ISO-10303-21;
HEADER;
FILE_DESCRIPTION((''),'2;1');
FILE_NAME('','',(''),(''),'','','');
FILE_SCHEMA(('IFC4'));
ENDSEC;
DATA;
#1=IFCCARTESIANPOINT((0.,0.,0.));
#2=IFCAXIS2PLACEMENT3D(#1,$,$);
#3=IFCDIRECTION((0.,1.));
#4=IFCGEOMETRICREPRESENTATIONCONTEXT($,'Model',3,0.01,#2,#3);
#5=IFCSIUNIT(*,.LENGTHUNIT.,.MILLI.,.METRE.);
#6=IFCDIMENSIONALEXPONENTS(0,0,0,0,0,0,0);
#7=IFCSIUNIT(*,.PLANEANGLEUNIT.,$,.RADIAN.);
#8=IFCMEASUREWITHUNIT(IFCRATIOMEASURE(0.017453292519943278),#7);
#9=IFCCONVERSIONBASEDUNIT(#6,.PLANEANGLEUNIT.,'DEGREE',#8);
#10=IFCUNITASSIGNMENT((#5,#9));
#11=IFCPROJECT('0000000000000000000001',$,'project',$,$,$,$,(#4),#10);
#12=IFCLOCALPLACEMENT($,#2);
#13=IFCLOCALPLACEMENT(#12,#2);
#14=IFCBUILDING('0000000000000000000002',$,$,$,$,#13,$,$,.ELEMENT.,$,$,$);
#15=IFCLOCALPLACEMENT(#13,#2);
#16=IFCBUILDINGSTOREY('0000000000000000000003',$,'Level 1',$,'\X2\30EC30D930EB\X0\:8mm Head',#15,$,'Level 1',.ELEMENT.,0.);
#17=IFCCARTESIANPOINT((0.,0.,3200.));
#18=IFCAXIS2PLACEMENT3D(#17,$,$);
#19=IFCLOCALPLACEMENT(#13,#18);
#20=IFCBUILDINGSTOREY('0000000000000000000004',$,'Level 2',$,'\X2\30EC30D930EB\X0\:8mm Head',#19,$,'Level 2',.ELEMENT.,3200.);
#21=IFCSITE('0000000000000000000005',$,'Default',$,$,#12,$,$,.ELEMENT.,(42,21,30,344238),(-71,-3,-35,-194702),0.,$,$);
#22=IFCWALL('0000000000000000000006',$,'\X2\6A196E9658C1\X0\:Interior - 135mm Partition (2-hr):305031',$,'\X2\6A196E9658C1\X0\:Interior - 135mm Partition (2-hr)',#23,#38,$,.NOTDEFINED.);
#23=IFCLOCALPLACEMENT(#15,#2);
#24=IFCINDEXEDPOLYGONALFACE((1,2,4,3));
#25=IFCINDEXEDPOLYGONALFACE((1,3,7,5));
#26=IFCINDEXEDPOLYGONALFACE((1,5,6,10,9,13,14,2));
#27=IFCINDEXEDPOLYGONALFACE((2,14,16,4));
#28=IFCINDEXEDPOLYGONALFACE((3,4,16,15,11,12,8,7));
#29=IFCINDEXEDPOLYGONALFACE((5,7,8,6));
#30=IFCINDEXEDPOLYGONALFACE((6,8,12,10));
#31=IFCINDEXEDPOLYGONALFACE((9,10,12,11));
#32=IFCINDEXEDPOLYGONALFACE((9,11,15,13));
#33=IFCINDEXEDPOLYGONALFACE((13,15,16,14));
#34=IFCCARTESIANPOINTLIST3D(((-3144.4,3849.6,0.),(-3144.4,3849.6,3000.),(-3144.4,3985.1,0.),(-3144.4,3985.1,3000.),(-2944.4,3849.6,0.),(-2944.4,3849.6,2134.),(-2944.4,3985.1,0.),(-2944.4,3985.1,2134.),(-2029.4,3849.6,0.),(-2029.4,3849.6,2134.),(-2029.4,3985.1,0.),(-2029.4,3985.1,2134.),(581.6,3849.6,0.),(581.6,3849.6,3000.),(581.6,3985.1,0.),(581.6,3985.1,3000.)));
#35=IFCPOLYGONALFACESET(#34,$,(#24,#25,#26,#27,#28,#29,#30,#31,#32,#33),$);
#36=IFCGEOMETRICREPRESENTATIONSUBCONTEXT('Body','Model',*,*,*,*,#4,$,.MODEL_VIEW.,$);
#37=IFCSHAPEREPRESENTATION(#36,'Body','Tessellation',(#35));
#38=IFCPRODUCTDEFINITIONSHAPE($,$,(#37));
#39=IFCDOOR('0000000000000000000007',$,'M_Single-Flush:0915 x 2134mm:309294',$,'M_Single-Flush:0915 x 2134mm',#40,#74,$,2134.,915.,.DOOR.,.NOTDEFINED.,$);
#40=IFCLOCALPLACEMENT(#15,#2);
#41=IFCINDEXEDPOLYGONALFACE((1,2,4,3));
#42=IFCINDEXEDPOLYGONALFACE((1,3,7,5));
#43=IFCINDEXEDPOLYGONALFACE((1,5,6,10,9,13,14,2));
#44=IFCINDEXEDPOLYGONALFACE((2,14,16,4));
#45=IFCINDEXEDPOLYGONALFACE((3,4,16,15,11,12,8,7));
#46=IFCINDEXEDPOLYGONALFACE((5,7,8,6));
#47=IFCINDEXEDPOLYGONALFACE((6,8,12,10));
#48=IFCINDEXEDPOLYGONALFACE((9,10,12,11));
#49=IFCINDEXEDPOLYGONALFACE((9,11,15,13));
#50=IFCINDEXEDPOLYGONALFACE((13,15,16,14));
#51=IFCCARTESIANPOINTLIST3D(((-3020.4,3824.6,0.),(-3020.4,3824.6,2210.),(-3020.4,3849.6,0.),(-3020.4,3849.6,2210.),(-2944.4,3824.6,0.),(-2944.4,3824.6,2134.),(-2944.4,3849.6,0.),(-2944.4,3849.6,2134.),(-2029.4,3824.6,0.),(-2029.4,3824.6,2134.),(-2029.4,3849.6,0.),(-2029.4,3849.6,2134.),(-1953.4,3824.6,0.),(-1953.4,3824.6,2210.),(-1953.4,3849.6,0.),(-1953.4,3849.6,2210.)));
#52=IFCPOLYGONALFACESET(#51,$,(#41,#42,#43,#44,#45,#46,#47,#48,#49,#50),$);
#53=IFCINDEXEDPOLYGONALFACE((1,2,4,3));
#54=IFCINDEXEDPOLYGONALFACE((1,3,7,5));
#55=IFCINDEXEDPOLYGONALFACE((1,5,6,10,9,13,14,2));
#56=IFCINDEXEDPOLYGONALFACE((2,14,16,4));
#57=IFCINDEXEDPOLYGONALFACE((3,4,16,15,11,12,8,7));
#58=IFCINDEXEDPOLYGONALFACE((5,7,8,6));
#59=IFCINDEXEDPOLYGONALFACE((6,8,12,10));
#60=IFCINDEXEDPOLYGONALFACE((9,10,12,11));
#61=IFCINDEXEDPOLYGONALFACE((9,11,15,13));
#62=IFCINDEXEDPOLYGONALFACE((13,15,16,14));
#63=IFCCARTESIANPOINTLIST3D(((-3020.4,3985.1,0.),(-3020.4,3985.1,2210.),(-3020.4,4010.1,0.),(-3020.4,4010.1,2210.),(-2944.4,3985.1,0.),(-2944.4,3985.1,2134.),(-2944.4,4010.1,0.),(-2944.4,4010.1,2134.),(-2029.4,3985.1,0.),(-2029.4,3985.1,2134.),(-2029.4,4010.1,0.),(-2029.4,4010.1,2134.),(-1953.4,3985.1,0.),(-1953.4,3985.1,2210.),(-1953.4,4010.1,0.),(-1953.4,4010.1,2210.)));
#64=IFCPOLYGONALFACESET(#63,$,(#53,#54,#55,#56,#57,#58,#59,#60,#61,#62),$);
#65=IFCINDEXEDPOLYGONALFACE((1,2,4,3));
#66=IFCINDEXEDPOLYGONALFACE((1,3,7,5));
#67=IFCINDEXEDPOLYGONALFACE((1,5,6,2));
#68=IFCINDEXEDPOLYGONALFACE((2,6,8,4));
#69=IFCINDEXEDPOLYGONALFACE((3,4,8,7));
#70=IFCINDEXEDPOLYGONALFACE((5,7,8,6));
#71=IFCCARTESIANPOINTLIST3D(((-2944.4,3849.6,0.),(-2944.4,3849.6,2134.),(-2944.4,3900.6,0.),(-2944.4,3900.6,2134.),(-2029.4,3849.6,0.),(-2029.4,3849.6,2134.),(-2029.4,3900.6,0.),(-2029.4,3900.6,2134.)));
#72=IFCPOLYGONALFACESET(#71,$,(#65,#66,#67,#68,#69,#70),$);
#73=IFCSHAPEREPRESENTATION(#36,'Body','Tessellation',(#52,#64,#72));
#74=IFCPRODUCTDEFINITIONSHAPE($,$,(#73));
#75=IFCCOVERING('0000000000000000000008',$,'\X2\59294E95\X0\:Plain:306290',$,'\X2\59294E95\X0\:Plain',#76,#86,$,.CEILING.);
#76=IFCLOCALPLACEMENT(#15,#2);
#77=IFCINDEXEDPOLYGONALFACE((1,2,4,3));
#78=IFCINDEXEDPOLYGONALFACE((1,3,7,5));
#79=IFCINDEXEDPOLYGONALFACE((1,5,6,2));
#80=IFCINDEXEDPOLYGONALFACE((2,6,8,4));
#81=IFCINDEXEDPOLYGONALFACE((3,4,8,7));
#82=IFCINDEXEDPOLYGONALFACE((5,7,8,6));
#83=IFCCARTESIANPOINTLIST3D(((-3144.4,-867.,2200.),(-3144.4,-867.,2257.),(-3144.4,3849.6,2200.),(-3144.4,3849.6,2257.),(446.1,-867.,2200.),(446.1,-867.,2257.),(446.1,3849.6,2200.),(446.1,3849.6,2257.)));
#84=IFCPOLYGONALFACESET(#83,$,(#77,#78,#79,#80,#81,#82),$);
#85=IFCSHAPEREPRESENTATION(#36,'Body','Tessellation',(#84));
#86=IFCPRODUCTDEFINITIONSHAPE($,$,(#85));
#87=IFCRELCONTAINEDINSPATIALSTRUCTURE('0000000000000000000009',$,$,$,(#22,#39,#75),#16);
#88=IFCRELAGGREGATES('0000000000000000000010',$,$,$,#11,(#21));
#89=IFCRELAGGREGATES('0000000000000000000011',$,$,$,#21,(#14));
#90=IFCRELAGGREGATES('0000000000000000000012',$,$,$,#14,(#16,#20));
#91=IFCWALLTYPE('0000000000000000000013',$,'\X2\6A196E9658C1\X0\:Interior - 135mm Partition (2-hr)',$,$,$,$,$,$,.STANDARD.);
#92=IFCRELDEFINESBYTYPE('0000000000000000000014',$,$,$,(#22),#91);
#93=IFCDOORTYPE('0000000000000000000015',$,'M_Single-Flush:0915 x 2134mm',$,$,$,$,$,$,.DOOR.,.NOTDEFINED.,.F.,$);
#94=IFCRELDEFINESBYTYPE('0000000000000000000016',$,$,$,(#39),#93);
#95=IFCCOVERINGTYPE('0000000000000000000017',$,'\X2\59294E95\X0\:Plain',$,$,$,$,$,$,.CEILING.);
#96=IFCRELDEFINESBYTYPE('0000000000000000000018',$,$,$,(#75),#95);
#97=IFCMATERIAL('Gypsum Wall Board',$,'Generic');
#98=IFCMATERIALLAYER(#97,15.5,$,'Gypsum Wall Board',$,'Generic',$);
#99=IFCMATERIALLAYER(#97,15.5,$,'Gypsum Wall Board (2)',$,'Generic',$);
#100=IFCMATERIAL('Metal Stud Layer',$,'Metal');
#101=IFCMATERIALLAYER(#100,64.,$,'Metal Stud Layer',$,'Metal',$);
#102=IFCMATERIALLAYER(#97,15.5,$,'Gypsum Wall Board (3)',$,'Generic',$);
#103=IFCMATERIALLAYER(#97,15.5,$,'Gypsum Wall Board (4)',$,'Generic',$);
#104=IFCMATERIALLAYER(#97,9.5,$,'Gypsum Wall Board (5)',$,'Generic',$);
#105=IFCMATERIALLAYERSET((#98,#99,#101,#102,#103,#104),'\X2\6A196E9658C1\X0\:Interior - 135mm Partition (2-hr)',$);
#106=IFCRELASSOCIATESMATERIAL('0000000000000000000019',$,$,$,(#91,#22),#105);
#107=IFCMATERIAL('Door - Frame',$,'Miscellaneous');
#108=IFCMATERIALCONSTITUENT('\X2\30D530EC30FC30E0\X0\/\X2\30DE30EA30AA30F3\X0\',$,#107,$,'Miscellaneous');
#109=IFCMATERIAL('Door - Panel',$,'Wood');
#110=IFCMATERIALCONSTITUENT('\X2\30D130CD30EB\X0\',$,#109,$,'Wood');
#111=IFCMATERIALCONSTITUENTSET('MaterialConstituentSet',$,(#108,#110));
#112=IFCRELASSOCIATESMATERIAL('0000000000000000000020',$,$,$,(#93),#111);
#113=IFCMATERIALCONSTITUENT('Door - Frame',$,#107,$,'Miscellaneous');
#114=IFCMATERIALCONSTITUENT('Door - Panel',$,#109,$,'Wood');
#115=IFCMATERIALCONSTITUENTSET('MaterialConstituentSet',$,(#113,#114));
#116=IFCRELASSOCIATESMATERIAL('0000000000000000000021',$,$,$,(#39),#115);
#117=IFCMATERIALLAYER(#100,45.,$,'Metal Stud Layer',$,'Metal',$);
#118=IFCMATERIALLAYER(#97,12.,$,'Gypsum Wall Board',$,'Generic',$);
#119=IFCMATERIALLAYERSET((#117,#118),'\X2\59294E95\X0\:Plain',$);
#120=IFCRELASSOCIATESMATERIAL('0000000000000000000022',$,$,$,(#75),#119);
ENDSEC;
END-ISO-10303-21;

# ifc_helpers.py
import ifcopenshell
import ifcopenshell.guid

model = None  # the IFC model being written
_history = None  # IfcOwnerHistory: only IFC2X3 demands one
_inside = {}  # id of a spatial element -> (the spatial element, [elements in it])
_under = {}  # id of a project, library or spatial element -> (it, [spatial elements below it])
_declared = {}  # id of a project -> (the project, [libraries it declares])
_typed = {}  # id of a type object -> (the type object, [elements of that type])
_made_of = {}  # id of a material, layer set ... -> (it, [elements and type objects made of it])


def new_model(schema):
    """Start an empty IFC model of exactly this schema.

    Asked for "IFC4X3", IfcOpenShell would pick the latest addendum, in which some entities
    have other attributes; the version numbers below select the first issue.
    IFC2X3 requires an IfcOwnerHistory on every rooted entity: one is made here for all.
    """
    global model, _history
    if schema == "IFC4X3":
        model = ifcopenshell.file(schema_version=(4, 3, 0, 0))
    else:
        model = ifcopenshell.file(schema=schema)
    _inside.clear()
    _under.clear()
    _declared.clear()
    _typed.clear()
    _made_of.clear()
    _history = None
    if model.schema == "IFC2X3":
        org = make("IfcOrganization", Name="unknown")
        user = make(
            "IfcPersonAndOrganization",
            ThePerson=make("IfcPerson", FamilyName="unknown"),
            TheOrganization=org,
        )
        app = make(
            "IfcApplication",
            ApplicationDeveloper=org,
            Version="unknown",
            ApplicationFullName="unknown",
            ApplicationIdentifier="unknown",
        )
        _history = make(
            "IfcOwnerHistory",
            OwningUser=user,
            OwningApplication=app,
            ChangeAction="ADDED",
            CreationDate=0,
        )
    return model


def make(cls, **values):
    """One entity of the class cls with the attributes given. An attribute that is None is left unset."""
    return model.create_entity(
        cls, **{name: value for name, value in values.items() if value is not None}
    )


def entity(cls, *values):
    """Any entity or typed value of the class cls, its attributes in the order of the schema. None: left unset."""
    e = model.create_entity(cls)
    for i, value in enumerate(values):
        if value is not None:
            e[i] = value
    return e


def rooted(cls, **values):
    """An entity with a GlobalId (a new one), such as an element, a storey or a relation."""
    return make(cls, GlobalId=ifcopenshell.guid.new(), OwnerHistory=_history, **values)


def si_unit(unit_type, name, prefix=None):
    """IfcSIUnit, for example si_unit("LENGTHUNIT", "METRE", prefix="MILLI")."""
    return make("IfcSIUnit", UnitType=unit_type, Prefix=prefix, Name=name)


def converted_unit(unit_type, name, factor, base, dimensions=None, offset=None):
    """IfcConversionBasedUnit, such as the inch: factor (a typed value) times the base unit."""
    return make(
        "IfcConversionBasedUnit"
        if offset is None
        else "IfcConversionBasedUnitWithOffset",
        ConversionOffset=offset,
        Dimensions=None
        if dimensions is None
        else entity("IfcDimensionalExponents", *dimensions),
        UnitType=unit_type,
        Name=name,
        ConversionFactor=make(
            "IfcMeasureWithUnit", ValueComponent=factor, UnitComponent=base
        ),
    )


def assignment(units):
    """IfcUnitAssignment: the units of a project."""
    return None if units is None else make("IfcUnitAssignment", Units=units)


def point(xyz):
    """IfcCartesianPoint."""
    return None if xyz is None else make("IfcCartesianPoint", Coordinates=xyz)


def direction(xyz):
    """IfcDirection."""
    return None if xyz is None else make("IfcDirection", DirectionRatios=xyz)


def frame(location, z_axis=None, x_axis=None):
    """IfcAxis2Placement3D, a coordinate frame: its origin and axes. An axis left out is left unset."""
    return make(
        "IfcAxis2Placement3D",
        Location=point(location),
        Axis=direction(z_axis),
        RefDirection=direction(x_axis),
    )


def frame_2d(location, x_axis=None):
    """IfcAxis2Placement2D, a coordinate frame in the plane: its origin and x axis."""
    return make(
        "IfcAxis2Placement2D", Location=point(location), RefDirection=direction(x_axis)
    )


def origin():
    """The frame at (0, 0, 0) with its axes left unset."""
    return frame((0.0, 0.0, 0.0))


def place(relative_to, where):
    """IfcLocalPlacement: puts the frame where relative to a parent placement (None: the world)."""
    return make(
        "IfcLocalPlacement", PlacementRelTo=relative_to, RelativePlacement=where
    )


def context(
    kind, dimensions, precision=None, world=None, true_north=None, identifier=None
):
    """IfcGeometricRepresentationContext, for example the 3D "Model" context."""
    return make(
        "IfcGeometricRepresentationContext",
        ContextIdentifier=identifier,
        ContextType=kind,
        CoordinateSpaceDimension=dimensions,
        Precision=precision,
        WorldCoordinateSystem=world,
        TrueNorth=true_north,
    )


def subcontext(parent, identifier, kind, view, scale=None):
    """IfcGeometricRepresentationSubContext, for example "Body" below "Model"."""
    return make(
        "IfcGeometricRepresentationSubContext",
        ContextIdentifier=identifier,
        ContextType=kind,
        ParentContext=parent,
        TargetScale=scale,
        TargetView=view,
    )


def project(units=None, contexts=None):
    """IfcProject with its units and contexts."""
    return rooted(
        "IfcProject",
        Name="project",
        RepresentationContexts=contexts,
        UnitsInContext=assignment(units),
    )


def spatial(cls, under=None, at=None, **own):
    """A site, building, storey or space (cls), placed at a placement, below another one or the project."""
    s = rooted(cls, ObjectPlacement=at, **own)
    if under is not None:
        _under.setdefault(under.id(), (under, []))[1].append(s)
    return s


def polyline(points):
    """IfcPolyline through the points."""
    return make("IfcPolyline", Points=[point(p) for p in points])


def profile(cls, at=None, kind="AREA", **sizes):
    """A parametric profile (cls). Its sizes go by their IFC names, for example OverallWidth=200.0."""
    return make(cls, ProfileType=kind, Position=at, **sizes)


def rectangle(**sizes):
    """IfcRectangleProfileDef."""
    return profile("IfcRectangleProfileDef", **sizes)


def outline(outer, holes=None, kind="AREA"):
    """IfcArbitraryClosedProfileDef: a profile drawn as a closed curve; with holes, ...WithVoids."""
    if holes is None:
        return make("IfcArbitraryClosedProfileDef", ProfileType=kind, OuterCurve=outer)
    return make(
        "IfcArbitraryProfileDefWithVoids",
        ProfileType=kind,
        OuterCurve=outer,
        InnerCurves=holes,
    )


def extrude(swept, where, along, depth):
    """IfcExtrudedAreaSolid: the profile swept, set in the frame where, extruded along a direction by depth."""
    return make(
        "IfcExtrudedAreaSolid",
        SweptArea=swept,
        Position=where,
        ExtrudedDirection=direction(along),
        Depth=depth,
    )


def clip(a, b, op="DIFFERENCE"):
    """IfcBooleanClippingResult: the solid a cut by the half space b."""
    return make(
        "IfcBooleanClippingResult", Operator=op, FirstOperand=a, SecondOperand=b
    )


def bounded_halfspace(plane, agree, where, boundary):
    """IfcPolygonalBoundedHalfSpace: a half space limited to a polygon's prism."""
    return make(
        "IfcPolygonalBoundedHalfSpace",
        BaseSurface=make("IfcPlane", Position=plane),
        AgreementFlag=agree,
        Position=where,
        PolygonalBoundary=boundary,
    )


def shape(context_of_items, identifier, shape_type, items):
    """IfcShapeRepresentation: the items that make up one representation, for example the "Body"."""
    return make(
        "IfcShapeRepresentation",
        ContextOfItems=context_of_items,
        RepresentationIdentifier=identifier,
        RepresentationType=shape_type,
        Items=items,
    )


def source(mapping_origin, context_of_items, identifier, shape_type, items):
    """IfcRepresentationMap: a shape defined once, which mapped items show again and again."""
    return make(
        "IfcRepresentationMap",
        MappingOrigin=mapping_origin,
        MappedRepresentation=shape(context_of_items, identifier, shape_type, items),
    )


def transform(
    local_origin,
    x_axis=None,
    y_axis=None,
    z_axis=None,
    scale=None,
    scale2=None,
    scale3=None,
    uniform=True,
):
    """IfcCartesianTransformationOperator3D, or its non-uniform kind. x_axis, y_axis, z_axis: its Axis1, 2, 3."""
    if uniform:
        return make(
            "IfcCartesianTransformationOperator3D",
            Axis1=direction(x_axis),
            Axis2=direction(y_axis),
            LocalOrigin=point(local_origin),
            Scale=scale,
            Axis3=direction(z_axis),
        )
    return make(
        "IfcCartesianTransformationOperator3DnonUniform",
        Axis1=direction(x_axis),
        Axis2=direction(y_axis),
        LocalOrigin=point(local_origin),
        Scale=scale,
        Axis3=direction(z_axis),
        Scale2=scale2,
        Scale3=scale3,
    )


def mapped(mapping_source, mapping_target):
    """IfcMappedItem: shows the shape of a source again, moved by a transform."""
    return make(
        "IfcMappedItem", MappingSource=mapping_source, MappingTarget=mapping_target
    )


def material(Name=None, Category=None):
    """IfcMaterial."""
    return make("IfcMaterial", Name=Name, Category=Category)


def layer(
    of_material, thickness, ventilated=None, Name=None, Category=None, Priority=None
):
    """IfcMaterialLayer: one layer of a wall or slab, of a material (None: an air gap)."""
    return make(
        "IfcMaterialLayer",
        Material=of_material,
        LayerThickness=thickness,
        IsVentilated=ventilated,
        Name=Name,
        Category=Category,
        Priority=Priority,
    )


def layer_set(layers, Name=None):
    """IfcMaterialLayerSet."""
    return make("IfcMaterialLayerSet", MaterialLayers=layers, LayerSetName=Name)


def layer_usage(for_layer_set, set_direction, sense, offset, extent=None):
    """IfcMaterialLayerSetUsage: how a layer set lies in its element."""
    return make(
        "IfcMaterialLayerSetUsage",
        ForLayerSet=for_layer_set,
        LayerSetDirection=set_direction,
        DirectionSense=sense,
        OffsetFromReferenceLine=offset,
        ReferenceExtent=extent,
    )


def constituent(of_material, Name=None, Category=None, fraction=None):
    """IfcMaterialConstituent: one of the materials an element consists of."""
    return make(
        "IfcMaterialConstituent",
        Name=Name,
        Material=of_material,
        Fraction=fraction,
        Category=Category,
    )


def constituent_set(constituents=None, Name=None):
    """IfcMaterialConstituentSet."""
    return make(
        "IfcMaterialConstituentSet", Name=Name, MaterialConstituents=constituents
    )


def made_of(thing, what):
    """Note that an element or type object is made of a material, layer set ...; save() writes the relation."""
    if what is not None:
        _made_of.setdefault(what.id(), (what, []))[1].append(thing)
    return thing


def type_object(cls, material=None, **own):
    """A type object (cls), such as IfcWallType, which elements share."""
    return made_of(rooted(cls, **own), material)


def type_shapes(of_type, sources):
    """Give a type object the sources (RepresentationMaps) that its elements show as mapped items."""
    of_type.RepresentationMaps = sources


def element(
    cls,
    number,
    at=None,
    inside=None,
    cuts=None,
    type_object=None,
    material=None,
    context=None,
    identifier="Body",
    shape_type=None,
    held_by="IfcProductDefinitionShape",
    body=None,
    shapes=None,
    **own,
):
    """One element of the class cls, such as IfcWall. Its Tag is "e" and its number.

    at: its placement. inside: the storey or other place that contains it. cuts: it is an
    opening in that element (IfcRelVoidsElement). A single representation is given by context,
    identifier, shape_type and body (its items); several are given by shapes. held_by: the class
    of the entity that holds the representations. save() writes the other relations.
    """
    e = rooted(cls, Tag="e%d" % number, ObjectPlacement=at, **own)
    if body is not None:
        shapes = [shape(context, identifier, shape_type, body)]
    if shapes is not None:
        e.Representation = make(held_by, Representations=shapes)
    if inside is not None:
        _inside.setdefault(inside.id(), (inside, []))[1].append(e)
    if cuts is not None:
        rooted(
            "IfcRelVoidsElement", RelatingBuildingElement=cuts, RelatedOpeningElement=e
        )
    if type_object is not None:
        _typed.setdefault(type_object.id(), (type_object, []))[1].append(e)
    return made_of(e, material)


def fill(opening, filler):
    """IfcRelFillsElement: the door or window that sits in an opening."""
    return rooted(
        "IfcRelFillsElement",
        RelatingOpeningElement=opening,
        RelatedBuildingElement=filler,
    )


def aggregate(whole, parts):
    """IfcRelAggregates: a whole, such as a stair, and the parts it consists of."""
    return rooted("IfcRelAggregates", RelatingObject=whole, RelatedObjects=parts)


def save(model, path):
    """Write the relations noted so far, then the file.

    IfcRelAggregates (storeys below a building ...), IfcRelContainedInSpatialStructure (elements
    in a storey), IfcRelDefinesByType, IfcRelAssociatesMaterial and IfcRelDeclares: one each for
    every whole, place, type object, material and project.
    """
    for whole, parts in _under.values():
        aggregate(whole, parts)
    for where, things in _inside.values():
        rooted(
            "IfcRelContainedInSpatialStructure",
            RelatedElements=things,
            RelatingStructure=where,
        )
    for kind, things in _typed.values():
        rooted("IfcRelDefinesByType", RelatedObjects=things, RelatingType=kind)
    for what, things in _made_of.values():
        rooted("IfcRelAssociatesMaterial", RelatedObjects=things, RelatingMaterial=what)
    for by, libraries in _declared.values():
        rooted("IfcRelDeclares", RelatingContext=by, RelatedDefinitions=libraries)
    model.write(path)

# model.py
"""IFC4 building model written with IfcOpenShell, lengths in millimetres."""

from ifc_helpers import new_model, entity, si_unit, converted_unit, direction, frame, frame_2d, origin, place, context, subcontext, project, spatial, polyline, rectangle, outline, extrude, clip, bounded_halfspace, source, transform, mapped, material, layer, layer_set, layer_usage, constituent, constituent_set, type_object, type_shapes, element, fill, save


model = new_model("IFC4")

# Units and contexts
model_context = context("Model", 3, precision=0.01, world=origin(), true_north=direction((0.0, 1.0)))
body_context = subcontext(model_context, "Body", "Model", "MODEL_VIEW")
ifc_project = project(units=[si_unit("LENGTHUNIT", "METRE", prefix="MILLI"), converted_unit("PLANEANGLEUNIT", "DEGREE", entity("IfcRatioMeasure", 0.017453292519943278), si_unit("PLANEANGLEUNIT", "RADIAN"), dimensions=[0, 0, 0, 0, 0, 0, 0])], contexts=[model_context])

# Site, building, storey
site_placement = place(None, origin())
site = spatial("IfcSite", under=ifc_project, at=site_placement, Name="Default", CompositionType="ELEMENT", RefLatitude=(42, 21, 30, 344238), RefLongitude=(-71, -3, -35, -194702), RefElevation=0.0)
building_placement = place(site_placement, origin())
building = spatial("IfcBuilding", under=site, at=building_placement, CompositionType="ELEMENT")
storey_1_placement = place(building_placement, origin())
storey_1 = spatial("IfcBuildingStorey", under=building, at=storey_1_placement, Name="Level 1", ObjectType="レベル:8mm Head", LongName="Level 1", CompositionType="ELEMENT", Elevation=0.0)

# Shared definitions
storey_2_placement = place(building_placement, frame((0.0, 0.0, 3200.0)))
storey_2 = spatial("IfcBuildingStorey", under=building, at=storey_2_placement, Name="Level 2", ObjectType="レベル:8mm Head", LongName="Level 2", CompositionType="ELEMENT", Elevation=3200.0)

# Shared definitions
ifc_material_1 = material(Name="Door - Frame", Category="Miscellaneous")
ifc_material_2 = material(Name="Door - Panel", Category="Wood")

# Wall, opening, door
ifc_material_3 = material(Name="Gypsum Wall Board", Category="Generic")
ifc_layer_1 = layer(ifc_material_3, 15.5, Name="Gypsum Wall Board", Category="Generic")
ifc_layer_2 = layer(ifc_material_3, 15.5, Name="Gypsum Wall Board (2)", Category="Generic")
ifc_material_4 = material(Name="Metal Stud Layer", Category="Metal")
ifc_layer_3 = layer(ifc_material_4, 64.0, Name="Metal Stud Layer", Category="Metal")
ifc_layer_4 = layer(ifc_material_3, 15.5, Name="Gypsum Wall Board (3)", Category="Generic")
ifc_layer_5 = layer(ifc_material_3, 15.5, Name="Gypsum Wall Board (4)", Category="Generic")
ifc_layer_6 = layer(ifc_material_3, 9.5, Name="Gypsum Wall Board (5)", Category="Generic")
ifc_layer_set_1 = layer_set([ifc_layer_1, ifc_layer_2, ifc_layer_3, ifc_layer_4, ifc_layer_5, ifc_layer_6], Name="標準壁:Interior - 135mm Partition (2-hr)")
ifc_layer_usage_1 = layer_usage(ifc_layer_set_1, "AXIS2", "NEGATIVE", 67.8)
wall_type_1 = type_object("IfcWallType", Name="標準壁:Interior - 135mm Partition (2-hr)", PredefinedType="STANDARD", material=ifc_layer_set_1)
wall_1_placement = place(storey_1_placement, frame((-3144.4, 3917.4, 0.0)))
wall_1 = element("IfcWall", 1, at=wall_1_placement, inside=storey_1, type_object=wall_type_1, material=ifc_layer_usage_1, Name="標準壁:Interior - 135mm Partition (2-hr):305031", ObjectType="標準壁:Interior - 135mm Partition (2-hr)", PredefinedType="NOTDEFINED", context=body_context, shape_type="Clipping", body=[
    clip(extrude(rectangle(XDim=3726.1, YDim=135.5, at=frame_2d((1863.0, 0.0), x_axis=(-1.0, 0.0))), origin(), (0.0, 0.0, 1.0), 3000.0), bounded_halfspace(frame((0.0, -67.8, 3000.0), z_axis=(0.0, 0.0, -1.0), x_axis=(1.0, 0.0, 0.0)), True, frame((0.0, -67.8, 3000.0)), polyline([(0.0, 0.0), (3590.6, 0.0), (3726.1, 0.0), (3726.1, 135.5), (0.0, 135.5), (0.0, 0.0)]))),
])
opening_1_placement = place(wall_1_placement, frame((1115.0, 67.7, 0.0)))
opening_1 = element("IfcOpeningElement", 2, at=opening_1_placement, cuts=wall_1, PredefinedType="OPENING", context=body_context, shape_type="SweptSolid", body=[
    extrude(rectangle(XDim=915.0, YDim=2134.0, at=frame_2d((1067.0, 457.5), x_axis=(0.0, 1.0))), frame((0.0, 0.0, 0.0), z_axis=(0.0, -1.0, 0.0), x_axis=(0.0, 0.0, 1.0)), (0.0, 0.0, 1.0), 135.5),
])
ifc_constituent_1 = constituent(ifc_material_1, Name="Door - Frame", Category="Miscellaneous")
ifc_constituent_2 = constituent(ifc_material_2, Name="Door - Panel", Category="Wood")
ifc_constituent_set_1 = constituent_set(constituents=[ifc_constituent_1, ifc_constituent_2], Name="MaterialConstituentSet")
ifc_constituent_3 = constituent(ifc_material_1, Name="フレーム/マリオン", Category="Miscellaneous")
ifc_constituent_4 = constituent(ifc_material_2, Name="パネル", Category="Wood")
ifc_constituent_set_2 = constituent_set(constituents=[ifc_constituent_3, ifc_constituent_4], Name="MaterialConstituentSet")
door_type_1 = type_object("IfcDoorType", Name="M_Single-Flush:0915 x 2134mm", OperationType="NOTDEFINED", ParameterTakesPrecedence=False, PredefinedType="DOOR", material=ifc_constituent_set_2)
shared_shape_1 = source(origin(), body_context, "Body", "SweptSolid", [
    extrude(outline(polyline([(-533.5, -1124.0), (533.5, -1124.0), (533.5, 1086.0), (457.5, 1086.0), (457.5, -1048.0), (-457.5, -1048.0), (-457.5, 1086.0), (-533.5, 1086.0), (-533.5, -1124.0)])), frame((457.5, 135.5, 1086.0), z_axis=(0.0, 1.0, 0.0), x_axis=(1.0, 0.0, 0.0)), (0.0, 0.0, 1.0), 25.0),
    extrude(outline(polyline([(-1124.0, -533.5), (1086.0, -533.5), (1086.0, -457.5), (-1048.0, -457.5), (-1048.0, 457.5), (1086.0, 457.5), (1086.0, 533.5), (-1124.0, 533.5), (-1124.0, -533.5)])), frame((457.5, -25.0, 1086.0), z_axis=(0.0, 1.0, 0.0), x_axis=(0.0, 0.0, -1.0)), (0.0, 0.0, 1.0), 25.0),
    extrude(rectangle(XDim=51.0, YDim=915.0, at=frame_2d((0.0, 0.0), x_axis=(1.0, 0.0))), frame((457.5, 110.0, 0.0), z_axis=(0.0, 0.0, 1.0), x_axis=(0.0, 1.0, 0.0)), (0.0, 0.0, 1.0), 2134.0),
])
type_shapes(door_type_1, [shared_shape_1])
door_1_placement = place(opening_1_placement, frame((0.0, 0.0, 0.0), z_axis=(0.0, 0.0, 1.0), x_axis=(-1.0, 0.0, 0.0)))
door_1 = element("IfcDoor", 3, at=door_1_placement, inside=storey_1, type_object=door_type_1, material=ifc_constituent_set_1, Name="M_Single-Flush:0915 x 2134mm:309294", ObjectType="M_Single-Flush:0915 x 2134mm", OperationType="NOTDEFINED", OverallHeight=2134.0, OverallWidth=915.0, PredefinedType="DOOR", context=body_context, shape_type="MappedRepresentation", body=[
    mapped(shared_shape_1, transform((0.0, 0.0, 0.0), scale=1.0)),
])
fill(opening_1, door_1)

# Covering
ifc_layer_7 = layer(ifc_material_4, 45.0, Name="Metal Stud Layer", Category="Metal")
ifc_layer_8 = layer(ifc_material_3, 12.0, Name="Gypsum Wall Board", Category="Generic")
ifc_layer_set_2 = layer_set([ifc_layer_7, ifc_layer_8], Name="天井:Plain")
ifc_layer_usage_2 = layer_usage(ifc_layer_set_2, "AXIS3", "POSITIVE", 0.0)
covering_type_1 = type_object("IfcCoveringType", Name="天井:Plain", PredefinedType="CEILING")
covering_1_placement = place(storey_1_placement, frame((-3144.4, -867.0, 2200.0)))
element("IfcCovering", 4, at=covering_1_placement, inside=storey_1, type_object=covering_type_1, material=ifc_layer_usage_2, Name="天井:Plain:306290", ObjectType="天井:Plain", PredefinedType="CEILING", context=body_context, shape_type="SweptSolid", body=[
    extrude(rectangle(XDim=3590.6, YDim=4716.6, at=frame_2d((0.0, 0.0), x_axis=(1.0, 0.0))), frame((1795.3, 2358.3, 0.0)), (0.0, 0.0, 1.0), 57.0),
])

save(model, "model.ifc")
